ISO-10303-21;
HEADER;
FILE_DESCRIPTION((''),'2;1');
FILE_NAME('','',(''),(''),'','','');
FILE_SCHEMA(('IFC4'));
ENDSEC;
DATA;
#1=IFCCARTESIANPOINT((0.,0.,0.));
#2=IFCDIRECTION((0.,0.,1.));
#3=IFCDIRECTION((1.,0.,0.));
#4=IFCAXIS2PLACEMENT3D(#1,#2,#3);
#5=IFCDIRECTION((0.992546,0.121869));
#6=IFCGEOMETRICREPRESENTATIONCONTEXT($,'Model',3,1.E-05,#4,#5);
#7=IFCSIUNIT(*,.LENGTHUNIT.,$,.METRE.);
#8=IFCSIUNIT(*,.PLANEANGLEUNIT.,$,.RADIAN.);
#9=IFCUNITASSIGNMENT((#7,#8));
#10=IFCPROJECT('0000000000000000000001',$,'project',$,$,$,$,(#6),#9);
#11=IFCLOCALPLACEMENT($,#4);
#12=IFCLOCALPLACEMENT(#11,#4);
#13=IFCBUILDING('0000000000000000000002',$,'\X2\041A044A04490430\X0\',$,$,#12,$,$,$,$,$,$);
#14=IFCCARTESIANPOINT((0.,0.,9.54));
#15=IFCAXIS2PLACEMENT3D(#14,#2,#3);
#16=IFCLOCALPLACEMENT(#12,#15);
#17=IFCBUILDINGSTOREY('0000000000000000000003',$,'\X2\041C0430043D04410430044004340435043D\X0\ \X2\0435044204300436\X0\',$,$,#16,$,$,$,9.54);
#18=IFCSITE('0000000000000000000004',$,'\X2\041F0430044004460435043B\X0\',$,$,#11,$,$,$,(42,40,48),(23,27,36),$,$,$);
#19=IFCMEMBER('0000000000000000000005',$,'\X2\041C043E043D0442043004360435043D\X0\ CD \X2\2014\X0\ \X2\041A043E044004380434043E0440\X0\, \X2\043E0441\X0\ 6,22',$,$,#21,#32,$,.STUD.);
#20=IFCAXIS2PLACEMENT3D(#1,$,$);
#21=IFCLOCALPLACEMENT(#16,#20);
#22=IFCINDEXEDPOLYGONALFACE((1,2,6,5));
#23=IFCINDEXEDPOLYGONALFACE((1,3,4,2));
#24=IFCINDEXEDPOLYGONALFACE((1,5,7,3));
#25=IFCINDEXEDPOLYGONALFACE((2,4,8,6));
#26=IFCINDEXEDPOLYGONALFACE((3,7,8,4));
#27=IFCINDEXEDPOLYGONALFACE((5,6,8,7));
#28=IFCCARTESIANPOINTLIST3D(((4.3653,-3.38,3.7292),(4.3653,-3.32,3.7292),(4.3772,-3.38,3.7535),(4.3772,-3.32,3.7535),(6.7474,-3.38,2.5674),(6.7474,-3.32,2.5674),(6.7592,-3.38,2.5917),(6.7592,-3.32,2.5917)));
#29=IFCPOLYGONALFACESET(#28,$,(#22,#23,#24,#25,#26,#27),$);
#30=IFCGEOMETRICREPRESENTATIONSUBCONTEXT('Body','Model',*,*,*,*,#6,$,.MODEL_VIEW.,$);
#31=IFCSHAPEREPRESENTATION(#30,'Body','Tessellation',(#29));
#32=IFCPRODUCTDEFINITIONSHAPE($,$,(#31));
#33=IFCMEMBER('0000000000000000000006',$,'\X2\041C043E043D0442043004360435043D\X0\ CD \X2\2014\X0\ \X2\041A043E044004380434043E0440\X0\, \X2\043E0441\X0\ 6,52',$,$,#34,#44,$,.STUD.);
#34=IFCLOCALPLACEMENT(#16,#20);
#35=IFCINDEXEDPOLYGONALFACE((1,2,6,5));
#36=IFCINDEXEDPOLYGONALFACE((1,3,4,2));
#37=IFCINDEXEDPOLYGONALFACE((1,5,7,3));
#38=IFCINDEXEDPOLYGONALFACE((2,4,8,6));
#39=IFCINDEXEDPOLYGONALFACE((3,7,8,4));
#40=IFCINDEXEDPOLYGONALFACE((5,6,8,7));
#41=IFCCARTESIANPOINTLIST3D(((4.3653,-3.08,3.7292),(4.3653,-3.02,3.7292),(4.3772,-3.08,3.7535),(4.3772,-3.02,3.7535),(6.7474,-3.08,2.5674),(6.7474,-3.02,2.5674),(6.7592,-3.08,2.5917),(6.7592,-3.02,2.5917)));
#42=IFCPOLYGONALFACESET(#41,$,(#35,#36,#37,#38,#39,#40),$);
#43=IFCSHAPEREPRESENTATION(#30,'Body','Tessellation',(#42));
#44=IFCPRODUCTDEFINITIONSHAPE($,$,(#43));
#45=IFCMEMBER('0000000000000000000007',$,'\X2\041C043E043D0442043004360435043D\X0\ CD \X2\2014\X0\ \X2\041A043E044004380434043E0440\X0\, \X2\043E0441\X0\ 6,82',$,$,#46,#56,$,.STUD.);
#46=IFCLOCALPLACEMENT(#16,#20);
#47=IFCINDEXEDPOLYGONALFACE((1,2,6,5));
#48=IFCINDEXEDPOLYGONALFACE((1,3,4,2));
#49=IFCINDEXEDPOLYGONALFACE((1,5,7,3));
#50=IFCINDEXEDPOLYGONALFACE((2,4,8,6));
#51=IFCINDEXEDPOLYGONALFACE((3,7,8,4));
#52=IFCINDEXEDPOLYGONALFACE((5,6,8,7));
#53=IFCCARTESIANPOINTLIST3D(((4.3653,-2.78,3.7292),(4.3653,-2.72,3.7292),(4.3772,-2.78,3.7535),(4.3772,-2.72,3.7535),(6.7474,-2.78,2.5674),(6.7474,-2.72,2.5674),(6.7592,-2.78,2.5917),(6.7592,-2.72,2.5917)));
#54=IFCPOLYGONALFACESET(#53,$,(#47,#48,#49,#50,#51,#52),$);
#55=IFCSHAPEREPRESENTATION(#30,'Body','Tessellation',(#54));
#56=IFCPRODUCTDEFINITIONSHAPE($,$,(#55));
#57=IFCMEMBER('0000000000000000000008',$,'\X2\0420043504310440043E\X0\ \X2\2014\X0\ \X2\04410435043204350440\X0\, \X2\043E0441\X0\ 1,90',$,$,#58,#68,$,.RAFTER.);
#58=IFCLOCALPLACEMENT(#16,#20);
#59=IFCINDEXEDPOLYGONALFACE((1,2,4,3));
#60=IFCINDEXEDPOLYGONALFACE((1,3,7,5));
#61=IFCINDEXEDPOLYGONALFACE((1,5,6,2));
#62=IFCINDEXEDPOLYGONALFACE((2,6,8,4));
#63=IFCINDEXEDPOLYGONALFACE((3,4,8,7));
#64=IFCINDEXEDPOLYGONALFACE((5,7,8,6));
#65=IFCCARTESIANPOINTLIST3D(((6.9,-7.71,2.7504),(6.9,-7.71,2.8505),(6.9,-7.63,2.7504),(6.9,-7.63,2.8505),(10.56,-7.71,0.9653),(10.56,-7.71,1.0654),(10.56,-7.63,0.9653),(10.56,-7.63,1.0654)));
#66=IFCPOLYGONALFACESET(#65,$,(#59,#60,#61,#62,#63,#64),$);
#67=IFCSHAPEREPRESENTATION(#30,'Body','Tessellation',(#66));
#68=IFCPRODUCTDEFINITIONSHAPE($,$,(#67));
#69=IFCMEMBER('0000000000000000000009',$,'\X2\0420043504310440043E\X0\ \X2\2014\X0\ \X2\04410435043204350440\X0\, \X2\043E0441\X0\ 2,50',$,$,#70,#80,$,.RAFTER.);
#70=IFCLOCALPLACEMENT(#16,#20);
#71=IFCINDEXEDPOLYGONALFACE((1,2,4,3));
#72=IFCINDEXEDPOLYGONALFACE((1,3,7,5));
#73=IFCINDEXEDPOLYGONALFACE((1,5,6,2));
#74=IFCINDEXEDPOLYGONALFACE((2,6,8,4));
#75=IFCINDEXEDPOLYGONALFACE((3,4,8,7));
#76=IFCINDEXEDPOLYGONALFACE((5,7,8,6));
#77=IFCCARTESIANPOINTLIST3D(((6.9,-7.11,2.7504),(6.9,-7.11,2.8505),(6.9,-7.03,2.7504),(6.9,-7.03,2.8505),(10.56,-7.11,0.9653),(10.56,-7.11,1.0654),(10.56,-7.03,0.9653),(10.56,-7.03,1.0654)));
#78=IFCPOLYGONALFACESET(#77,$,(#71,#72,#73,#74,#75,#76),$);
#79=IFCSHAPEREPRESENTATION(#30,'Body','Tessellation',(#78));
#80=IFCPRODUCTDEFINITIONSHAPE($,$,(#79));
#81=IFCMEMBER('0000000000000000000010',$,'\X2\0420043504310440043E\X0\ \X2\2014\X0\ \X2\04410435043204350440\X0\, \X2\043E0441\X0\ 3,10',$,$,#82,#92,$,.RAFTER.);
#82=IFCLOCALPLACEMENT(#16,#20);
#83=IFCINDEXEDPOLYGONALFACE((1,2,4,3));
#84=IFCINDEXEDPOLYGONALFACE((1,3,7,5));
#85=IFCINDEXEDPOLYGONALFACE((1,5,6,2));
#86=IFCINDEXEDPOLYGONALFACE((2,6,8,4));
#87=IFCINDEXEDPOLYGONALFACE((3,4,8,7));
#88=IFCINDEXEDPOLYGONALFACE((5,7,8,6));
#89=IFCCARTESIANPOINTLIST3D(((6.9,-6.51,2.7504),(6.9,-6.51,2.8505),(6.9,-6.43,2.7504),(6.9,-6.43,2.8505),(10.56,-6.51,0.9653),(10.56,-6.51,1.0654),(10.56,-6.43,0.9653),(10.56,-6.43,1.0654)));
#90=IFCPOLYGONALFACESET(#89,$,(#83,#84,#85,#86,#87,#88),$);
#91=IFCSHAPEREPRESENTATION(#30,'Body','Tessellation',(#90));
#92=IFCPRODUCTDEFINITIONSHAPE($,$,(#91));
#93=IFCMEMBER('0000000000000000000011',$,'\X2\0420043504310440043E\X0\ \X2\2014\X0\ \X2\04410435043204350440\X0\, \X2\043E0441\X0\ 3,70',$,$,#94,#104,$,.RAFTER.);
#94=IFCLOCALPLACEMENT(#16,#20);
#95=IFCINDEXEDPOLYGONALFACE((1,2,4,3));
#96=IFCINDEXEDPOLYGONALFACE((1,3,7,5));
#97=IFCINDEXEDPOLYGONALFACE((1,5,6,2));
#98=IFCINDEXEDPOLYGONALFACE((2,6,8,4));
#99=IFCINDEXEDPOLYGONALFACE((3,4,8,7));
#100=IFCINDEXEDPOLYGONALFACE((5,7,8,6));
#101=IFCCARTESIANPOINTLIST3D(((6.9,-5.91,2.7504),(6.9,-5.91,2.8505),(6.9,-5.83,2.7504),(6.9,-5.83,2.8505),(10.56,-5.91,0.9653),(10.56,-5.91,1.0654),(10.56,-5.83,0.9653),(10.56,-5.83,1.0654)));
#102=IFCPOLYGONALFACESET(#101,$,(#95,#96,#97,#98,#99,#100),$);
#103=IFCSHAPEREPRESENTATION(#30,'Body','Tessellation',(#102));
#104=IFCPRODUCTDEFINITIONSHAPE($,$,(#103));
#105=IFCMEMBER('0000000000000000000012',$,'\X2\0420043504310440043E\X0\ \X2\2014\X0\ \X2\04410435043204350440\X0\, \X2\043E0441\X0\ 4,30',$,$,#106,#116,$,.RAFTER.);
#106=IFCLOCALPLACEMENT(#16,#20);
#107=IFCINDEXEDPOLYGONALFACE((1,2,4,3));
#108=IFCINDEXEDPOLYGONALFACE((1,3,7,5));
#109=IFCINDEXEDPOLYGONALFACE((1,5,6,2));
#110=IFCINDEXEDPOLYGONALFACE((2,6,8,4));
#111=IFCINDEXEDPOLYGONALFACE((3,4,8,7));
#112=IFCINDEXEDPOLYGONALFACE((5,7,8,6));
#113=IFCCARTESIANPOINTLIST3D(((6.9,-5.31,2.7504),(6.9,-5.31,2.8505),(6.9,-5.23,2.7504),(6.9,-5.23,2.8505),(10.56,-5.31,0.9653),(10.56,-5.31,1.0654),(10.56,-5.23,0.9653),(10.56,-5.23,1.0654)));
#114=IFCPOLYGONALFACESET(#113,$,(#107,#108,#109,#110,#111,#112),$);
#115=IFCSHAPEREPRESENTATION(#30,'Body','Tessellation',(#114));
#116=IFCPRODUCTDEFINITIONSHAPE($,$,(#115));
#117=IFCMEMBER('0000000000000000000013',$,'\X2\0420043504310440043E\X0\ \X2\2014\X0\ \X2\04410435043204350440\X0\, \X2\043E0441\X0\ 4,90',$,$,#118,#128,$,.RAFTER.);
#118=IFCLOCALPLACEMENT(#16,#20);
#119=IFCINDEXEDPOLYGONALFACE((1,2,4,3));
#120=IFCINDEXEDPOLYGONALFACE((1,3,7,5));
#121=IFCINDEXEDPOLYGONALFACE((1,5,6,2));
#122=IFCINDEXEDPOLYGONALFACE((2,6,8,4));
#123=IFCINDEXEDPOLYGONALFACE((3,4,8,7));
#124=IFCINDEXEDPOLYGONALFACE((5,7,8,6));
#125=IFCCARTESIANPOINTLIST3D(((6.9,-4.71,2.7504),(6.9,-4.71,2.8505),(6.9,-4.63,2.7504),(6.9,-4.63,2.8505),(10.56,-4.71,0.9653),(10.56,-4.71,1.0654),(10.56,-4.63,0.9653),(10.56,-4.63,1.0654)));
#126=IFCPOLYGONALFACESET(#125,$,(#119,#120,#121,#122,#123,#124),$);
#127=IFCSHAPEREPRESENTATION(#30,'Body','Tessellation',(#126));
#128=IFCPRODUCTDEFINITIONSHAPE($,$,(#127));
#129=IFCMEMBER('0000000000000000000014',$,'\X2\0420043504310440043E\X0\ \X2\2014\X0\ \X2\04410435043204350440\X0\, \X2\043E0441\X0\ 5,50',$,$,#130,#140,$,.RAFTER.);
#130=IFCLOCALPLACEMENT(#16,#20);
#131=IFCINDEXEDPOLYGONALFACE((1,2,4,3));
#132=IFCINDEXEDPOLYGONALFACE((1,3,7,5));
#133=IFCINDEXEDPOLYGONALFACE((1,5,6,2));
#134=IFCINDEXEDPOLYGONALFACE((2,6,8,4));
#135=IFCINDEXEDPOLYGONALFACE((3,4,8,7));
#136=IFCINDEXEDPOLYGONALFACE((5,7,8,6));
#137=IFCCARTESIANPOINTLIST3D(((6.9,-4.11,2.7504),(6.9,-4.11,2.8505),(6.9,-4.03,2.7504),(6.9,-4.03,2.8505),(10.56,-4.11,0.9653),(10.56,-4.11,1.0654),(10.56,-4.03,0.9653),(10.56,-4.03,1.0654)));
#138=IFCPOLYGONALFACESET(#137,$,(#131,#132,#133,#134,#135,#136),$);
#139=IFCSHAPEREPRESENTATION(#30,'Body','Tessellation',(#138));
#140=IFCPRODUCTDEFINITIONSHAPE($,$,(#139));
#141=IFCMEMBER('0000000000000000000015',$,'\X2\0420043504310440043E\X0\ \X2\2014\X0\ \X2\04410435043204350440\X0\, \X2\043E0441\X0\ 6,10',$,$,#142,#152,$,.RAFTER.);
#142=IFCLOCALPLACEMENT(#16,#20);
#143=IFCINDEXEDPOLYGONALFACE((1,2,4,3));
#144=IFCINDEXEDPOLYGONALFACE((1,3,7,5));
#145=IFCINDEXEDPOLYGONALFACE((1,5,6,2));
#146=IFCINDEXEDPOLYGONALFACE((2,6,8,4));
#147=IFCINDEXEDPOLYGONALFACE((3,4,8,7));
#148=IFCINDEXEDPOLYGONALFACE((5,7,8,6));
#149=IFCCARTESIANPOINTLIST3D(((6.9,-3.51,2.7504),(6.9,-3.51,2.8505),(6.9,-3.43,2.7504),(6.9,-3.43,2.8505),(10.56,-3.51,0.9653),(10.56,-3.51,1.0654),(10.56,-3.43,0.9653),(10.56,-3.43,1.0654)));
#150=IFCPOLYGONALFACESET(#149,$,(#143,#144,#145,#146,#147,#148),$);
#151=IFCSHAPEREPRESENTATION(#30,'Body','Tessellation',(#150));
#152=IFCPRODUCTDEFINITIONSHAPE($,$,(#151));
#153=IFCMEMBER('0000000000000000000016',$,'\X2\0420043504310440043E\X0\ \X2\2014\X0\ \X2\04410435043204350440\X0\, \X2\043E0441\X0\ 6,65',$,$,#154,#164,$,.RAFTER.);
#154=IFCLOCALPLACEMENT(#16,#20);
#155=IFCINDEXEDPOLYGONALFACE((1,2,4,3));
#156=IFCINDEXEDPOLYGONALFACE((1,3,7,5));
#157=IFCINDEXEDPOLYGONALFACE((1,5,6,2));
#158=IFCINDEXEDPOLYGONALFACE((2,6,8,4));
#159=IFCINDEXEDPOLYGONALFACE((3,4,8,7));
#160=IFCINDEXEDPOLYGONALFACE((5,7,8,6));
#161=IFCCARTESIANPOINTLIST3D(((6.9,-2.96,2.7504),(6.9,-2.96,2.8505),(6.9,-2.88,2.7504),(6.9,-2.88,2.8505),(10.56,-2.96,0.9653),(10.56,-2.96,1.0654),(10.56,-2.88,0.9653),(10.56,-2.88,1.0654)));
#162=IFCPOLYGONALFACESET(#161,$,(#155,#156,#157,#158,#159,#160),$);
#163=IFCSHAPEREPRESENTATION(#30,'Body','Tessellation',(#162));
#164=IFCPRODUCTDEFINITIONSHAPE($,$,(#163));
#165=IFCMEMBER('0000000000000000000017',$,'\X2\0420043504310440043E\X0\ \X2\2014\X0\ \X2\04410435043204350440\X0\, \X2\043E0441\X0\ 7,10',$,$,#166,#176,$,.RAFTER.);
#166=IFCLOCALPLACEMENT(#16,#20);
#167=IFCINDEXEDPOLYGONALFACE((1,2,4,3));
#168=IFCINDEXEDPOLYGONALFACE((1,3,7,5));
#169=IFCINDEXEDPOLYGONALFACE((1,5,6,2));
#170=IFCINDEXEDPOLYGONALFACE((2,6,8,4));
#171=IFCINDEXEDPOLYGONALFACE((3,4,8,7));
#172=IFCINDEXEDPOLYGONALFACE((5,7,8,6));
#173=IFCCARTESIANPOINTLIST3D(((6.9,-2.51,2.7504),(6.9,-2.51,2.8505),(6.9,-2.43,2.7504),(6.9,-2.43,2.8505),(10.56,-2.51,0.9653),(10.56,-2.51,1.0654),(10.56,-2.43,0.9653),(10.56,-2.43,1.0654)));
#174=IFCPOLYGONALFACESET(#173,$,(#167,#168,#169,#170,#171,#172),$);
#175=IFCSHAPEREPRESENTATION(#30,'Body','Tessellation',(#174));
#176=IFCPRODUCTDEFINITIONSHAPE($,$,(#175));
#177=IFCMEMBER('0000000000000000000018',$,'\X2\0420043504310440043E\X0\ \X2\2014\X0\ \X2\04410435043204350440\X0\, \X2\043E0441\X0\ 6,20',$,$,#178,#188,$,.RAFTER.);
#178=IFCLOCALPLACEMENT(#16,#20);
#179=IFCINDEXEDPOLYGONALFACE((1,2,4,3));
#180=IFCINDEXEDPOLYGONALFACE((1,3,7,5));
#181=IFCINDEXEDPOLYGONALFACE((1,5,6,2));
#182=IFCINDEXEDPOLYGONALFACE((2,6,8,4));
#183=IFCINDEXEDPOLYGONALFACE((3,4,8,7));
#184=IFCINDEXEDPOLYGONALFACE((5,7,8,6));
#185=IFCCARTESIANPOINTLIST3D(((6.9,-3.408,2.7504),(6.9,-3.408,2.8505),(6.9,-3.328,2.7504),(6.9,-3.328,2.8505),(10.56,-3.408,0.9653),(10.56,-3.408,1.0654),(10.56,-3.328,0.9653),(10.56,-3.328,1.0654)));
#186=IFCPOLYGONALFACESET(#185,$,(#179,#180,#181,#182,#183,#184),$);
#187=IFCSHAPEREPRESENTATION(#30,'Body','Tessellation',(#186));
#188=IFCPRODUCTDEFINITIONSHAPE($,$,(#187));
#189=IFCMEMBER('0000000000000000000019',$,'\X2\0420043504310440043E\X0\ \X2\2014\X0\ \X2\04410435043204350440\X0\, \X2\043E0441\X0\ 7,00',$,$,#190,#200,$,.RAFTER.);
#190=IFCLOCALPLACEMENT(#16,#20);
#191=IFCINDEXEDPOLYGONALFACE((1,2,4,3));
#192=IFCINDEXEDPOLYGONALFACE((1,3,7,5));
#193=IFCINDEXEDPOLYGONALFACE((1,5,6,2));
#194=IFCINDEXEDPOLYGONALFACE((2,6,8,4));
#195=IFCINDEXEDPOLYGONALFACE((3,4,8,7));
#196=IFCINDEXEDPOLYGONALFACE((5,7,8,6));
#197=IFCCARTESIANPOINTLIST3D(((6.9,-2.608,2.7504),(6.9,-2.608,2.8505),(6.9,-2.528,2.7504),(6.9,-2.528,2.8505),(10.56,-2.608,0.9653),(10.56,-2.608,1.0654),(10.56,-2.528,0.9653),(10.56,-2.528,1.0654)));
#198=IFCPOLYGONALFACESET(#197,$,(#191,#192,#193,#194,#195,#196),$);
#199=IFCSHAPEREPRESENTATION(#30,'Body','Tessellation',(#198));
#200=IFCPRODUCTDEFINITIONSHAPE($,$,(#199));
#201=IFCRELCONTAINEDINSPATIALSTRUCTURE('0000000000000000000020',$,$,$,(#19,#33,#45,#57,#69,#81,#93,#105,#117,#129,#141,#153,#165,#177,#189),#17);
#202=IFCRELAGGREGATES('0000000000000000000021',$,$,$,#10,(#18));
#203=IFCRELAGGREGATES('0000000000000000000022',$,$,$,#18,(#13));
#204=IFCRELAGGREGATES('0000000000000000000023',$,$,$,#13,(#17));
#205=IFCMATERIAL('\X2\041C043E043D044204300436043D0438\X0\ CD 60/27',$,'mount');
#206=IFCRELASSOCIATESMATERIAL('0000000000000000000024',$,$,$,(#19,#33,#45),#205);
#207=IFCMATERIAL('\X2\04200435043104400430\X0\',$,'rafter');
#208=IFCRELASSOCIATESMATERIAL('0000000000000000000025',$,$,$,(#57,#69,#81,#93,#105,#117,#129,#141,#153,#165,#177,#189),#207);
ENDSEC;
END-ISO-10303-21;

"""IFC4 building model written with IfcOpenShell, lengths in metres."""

from ifc_helpers import new_model, si_unit, direction, frame, origin_with_axes, place, context, subcontext, project, spatial, polyline, outline, extrude, material, element, save


model = new_model("IFC4")

# Units and contexts
model_context = context("Model", 3, precision=1e-05, world=origin_with_axes(), true_north=direction((0.992546, 0.121869)))
body_context = subcontext(model_context, "Body", "Model", "MODEL_VIEW")
ifc_project = project(units=[si_unit("LENGTHUNIT", "METRE"), si_unit("PLANEANGLEUNIT", "RADIAN")], contexts=[model_context])

# Site, building, storey
site_placement = place(None, origin_with_axes())
site = spatial("IfcSite", under=ifc_project, at=site_placement, Name="Парцел", RefLatitude=(42, 40, 48), RefLongitude=(23, 27, 36))
building_placement = place(site_placement, origin_with_axes())
building = spatial("IfcBuilding", under=site, at=building_placement, Name="Къща")
storey_placement = place(building_placement, frame((0.0, 0.0, 9.54), z_axis=(0.0, 0.0, 1.0), x_axis=(1.0, 0.0, 0.0)))
storey = spatial("IfcBuildingStorey", under=building, at=storey_placement, Name="Мансарден етаж", Elevation=9.54)

# Members
ifc_material_1 = material(Name="Монтажни CD 60/27", Category="mount")
member_1_placement = place(storey_placement, origin_with_axes())
element("IfcMember", 1, at=member_1_placement, inside=storey, material=ifc_material_1, Name="Монтажен CD — Коридор, ос 6,22", PredefinedType="STUD", context=body_context, shape_type="SweptSolid", body=[
    extrude(outline(polyline([(6.7474, -2.5674), (4.3653, -3.7292), (4.3772, -3.7535), (6.7592, -2.5917), (6.7474, -2.5674)])), frame((0.0, -3.38, 0.0), z_axis=(0.0, 1.0, 0.0), x_axis=(1.0, 0.0, 0.0)), (0.0, 0.0, 1.0), 0.06),
])
member_2_placement = place(storey_placement, origin_with_axes())
element("IfcMember", 2, at=member_2_placement, inside=storey, material=ifc_material_1, Name="Монтажен CD — Коридор, ос 6,52", PredefinedType="STUD", context=body_context, shape_type="SweptSolid", body=[
    extrude(outline(polyline([(6.7474, -2.5674), (4.3653, -3.7292), (4.3772, -3.7535), (6.7592, -2.5917), (6.7474, -2.5674)])), frame((0.0, -3.08, 0.0), z_axis=(0.0, 1.0, 0.0), x_axis=(1.0, 0.0, 0.0)), (0.0, 0.0, 1.0), 0.06),
])
member_3_placement = place(storey_placement, origin_with_axes())
element("IfcMember", 3, at=member_3_placement, inside=storey, material=ifc_material_1, Name="Монтажен CD — Коридор, ос 6,82", PredefinedType="STUD", context=body_context, shape_type="SweptSolid", body=[
    extrude(outline(polyline([(6.7474, -2.5674), (4.3653, -3.7292), (4.3772, -3.7535), (6.7592, -2.5917), (6.7474, -2.5674)])), frame((0.0, -2.78, 0.0), z_axis=(0.0, 1.0, 0.0), x_axis=(1.0, 0.0, 0.0)), (0.0, 0.0, 1.0), 0.06),
])
ifc_material_2 = material(Name="Ребра", Category="rafter")
member_4_placement = place(storey_placement, origin_with_axes())
element("IfcMember", 4, at=member_4_placement, inside=storey, material=ifc_material_2, Name="Ребро — север, ос 1,90", PredefinedType="RAFTER", context=body_context, shape_type="SweptSolid", body=[
    extrude(outline(polyline([(10.56, -0.9653), (6.9, -2.7504), (6.9, -2.8505), (10.56, -1.0654), (10.56, -0.9653)])), frame((0.0, -7.71, 0.0), z_axis=(0.0, 1.0, 0.0), x_axis=(1.0, 0.0, 0.0)), (0.0, 0.0, 1.0), 0.08),
])
member_5_placement = place(storey_placement, origin_with_axes())
element("IfcMember", 5, at=member_5_placement, inside=storey, material=ifc_material_2, Name="Ребро — север, ос 2,50", PredefinedType="RAFTER", context=body_context, shape_type="SweptSolid", body=[
    extrude(outline(polyline([(10.56, -0.9653), (6.9, -2.7504), (6.9, -2.8505), (10.56, -1.0654), (10.56, -0.9653)])), frame((0.0, -7.11, 0.0), z_axis=(0.0, 1.0, 0.0), x_axis=(1.0, 0.0, 0.0)), (0.0, 0.0, 1.0), 0.08),
])
member_6_placement = place(storey_placement, origin_with_axes())
element("IfcMember", 6, at=member_6_placement, inside=storey, material=ifc_material_2, Name="Ребро — север, ос 3,10", PredefinedType="RAFTER", context=body_context, shape_type="SweptSolid", body=[
    extrude(outline(polyline([(10.56, -0.9653), (6.9, -2.7504), (6.9, -2.8505), (10.56, -1.0654), (10.56, -0.9653)])), frame((0.0, -6.51, 0.0), z_axis=(0.0, 1.0, 0.0), x_axis=(1.0, 0.0, 0.0)), (0.0, 0.0, 1.0), 0.08),
])
member_7_placement = place(storey_placement, origin_with_axes())
element("IfcMember", 7, at=member_7_placement, inside=storey, material=ifc_material_2, Name="Ребро — север, ос 3,70", PredefinedType="RAFTER", context=body_context, shape_type="SweptSolid", body=[
    extrude(outline(polyline([(10.56, -0.9653), (6.9, -2.7504), (6.9, -2.8505), (10.56, -1.0654), (10.56, -0.9653)])), frame((0.0, -5.91, 0.0), z_axis=(0.0, 1.0, 0.0), x_axis=(1.0, 0.0, 0.0)), (0.0, 0.0, 1.0), 0.08),
])
member_8_placement = place(storey_placement, origin_with_axes())
element("IfcMember", 8, at=member_8_placement, inside=storey, material=ifc_material_2, Name="Ребро — север, ос 4,30", PredefinedType="RAFTER", context=body_context, shape_type="SweptSolid", body=[
    extrude(outline(polyline([(10.56, -0.9653), (6.9, -2.7504), (6.9, -2.8505), (10.56, -1.0654), (10.56, -0.9653)])), frame((0.0, -5.31, 0.0), z_axis=(0.0, 1.0, 0.0), x_axis=(1.0, 0.0, 0.0)), (0.0, 0.0, 1.0), 0.08),
])
member_9_placement = place(storey_placement, origin_with_axes())
element("IfcMember", 9, at=member_9_placement, inside=storey, material=ifc_material_2, Name="Ребро — север, ос 4,90", PredefinedType="RAFTER", context=body_context, shape_type="SweptSolid", body=[
    extrude(outline(polyline([(10.56, -0.9653), (6.9, -2.7504), (6.9, -2.8505), (10.56, -1.0654), (10.56, -0.9653)])), frame((0.0, -4.71, 0.0), z_axis=(0.0, 1.0, 0.0), x_axis=(1.0, 0.0, 0.0)), (0.0, 0.0, 1.0), 0.08),
])
member_10_placement = place(storey_placement, origin_with_axes())
element("IfcMember", 10, at=member_10_placement, inside=storey, material=ifc_material_2, Name="Ребро — север, ос 5,50", PredefinedType="RAFTER", context=body_context, shape_type="SweptSolid", body=[
    extrude(outline(polyline([(10.56, -0.9653), (6.9, -2.7504), (6.9, -2.8505), (10.56, -1.0654), (10.56, -0.9653)])), frame((0.0, -4.11, 0.0), z_axis=(0.0, 1.0, 0.0), x_axis=(1.0, 0.0, 0.0)), (0.0, 0.0, 1.0), 0.08),
])
member_11_placement = place(storey_placement, origin_with_axes())
element("IfcMember", 11, at=member_11_placement, inside=storey, material=ifc_material_2, Name="Ребро — север, ос 6,10", PredefinedType="RAFTER", context=body_context, shape_type="SweptSolid", body=[
    extrude(outline(polyline([(10.56, -0.9653), (6.9, -2.7504), (6.9, -2.8505), (10.56, -1.0654), (10.56, -0.9653)])), frame((0.0, -3.51, 0.0), z_axis=(0.0, 1.0, 0.0), x_axis=(1.0, 0.0, 0.0)), (0.0, 0.0, 1.0), 0.08),
])
member_12_placement = place(storey_placement, origin_with_axes())
element("IfcMember", 12, at=member_12_placement, inside=storey, material=ifc_material_2, Name="Ребро — север, ос 6,65", PredefinedType="RAFTER", context=body_context, shape_type="SweptSolid", body=[
    extrude(outline(polyline([(10.56, -0.9653), (6.9, -2.7504), (6.9, -2.8505), (10.56, -1.0654), (10.56, -0.9653)])), frame((0.0, -2.96, 0.0), z_axis=(0.0, 1.0, 0.0), x_axis=(1.0, 0.0, 0.0)), (0.0, 0.0, 1.0), 0.08),
])
member_13_placement = place(storey_placement, origin_with_axes())
element("IfcMember", 13, at=member_13_placement, inside=storey, material=ifc_material_2, Name="Ребро — север, ос 7,10", PredefinedType="RAFTER", context=body_context, shape_type="SweptSolid", body=[
    extrude(outline(polyline([(10.56, -0.9653), (6.9, -2.7504), (6.9, -2.8505), (10.56, -1.0654), (10.56, -0.9653)])), frame((0.0, -2.51, 0.0), z_axis=(0.0, 1.0, 0.0), x_axis=(1.0, 0.0, 0.0)), (0.0, 0.0, 1.0), 0.08),
])
member_14_placement = place(storey_placement, origin_with_axes())
element("IfcMember", 14, at=member_14_placement, inside=storey, material=ifc_material_2, Name="Ребро — север, ос 6,20", PredefinedType="RAFTER", context=body_context, shape_type="SweptSolid", body=[
    extrude(outline(polyline([(10.56, -0.9653), (6.9, -2.7504), (6.9, -2.8505), (10.56, -1.0654), (10.56, -0.9653)])), frame((0.0, -3.408, 0.0), z_axis=(0.0, 1.0, 0.0), x_axis=(1.0, 0.0, 0.0)), (0.0, 0.0, 1.0), 0.08),
])
member_15_placement = place(storey_placement, origin_with_axes())
element("IfcMember", 15, at=member_15_placement, inside=storey, material=ifc_material_2, Name="Ребро — север, ос 7,00", PredefinedType="RAFTER", context=body_context, shape_type="SweptSolid", body=[
    extrude(outline(polyline([(10.56, -0.9653), (6.9, -2.7504), (6.9, -2.8505), (10.56, -1.0654), (10.56, -0.9653)])), frame((0.0, -2.608, 0.0), z_axis=(0.0, 1.0, 0.0), x_axis=(1.0, 0.0, 0.0)), (0.0, 0.0, 1.0), 0.08),
])

save(model, "model.ifc")
